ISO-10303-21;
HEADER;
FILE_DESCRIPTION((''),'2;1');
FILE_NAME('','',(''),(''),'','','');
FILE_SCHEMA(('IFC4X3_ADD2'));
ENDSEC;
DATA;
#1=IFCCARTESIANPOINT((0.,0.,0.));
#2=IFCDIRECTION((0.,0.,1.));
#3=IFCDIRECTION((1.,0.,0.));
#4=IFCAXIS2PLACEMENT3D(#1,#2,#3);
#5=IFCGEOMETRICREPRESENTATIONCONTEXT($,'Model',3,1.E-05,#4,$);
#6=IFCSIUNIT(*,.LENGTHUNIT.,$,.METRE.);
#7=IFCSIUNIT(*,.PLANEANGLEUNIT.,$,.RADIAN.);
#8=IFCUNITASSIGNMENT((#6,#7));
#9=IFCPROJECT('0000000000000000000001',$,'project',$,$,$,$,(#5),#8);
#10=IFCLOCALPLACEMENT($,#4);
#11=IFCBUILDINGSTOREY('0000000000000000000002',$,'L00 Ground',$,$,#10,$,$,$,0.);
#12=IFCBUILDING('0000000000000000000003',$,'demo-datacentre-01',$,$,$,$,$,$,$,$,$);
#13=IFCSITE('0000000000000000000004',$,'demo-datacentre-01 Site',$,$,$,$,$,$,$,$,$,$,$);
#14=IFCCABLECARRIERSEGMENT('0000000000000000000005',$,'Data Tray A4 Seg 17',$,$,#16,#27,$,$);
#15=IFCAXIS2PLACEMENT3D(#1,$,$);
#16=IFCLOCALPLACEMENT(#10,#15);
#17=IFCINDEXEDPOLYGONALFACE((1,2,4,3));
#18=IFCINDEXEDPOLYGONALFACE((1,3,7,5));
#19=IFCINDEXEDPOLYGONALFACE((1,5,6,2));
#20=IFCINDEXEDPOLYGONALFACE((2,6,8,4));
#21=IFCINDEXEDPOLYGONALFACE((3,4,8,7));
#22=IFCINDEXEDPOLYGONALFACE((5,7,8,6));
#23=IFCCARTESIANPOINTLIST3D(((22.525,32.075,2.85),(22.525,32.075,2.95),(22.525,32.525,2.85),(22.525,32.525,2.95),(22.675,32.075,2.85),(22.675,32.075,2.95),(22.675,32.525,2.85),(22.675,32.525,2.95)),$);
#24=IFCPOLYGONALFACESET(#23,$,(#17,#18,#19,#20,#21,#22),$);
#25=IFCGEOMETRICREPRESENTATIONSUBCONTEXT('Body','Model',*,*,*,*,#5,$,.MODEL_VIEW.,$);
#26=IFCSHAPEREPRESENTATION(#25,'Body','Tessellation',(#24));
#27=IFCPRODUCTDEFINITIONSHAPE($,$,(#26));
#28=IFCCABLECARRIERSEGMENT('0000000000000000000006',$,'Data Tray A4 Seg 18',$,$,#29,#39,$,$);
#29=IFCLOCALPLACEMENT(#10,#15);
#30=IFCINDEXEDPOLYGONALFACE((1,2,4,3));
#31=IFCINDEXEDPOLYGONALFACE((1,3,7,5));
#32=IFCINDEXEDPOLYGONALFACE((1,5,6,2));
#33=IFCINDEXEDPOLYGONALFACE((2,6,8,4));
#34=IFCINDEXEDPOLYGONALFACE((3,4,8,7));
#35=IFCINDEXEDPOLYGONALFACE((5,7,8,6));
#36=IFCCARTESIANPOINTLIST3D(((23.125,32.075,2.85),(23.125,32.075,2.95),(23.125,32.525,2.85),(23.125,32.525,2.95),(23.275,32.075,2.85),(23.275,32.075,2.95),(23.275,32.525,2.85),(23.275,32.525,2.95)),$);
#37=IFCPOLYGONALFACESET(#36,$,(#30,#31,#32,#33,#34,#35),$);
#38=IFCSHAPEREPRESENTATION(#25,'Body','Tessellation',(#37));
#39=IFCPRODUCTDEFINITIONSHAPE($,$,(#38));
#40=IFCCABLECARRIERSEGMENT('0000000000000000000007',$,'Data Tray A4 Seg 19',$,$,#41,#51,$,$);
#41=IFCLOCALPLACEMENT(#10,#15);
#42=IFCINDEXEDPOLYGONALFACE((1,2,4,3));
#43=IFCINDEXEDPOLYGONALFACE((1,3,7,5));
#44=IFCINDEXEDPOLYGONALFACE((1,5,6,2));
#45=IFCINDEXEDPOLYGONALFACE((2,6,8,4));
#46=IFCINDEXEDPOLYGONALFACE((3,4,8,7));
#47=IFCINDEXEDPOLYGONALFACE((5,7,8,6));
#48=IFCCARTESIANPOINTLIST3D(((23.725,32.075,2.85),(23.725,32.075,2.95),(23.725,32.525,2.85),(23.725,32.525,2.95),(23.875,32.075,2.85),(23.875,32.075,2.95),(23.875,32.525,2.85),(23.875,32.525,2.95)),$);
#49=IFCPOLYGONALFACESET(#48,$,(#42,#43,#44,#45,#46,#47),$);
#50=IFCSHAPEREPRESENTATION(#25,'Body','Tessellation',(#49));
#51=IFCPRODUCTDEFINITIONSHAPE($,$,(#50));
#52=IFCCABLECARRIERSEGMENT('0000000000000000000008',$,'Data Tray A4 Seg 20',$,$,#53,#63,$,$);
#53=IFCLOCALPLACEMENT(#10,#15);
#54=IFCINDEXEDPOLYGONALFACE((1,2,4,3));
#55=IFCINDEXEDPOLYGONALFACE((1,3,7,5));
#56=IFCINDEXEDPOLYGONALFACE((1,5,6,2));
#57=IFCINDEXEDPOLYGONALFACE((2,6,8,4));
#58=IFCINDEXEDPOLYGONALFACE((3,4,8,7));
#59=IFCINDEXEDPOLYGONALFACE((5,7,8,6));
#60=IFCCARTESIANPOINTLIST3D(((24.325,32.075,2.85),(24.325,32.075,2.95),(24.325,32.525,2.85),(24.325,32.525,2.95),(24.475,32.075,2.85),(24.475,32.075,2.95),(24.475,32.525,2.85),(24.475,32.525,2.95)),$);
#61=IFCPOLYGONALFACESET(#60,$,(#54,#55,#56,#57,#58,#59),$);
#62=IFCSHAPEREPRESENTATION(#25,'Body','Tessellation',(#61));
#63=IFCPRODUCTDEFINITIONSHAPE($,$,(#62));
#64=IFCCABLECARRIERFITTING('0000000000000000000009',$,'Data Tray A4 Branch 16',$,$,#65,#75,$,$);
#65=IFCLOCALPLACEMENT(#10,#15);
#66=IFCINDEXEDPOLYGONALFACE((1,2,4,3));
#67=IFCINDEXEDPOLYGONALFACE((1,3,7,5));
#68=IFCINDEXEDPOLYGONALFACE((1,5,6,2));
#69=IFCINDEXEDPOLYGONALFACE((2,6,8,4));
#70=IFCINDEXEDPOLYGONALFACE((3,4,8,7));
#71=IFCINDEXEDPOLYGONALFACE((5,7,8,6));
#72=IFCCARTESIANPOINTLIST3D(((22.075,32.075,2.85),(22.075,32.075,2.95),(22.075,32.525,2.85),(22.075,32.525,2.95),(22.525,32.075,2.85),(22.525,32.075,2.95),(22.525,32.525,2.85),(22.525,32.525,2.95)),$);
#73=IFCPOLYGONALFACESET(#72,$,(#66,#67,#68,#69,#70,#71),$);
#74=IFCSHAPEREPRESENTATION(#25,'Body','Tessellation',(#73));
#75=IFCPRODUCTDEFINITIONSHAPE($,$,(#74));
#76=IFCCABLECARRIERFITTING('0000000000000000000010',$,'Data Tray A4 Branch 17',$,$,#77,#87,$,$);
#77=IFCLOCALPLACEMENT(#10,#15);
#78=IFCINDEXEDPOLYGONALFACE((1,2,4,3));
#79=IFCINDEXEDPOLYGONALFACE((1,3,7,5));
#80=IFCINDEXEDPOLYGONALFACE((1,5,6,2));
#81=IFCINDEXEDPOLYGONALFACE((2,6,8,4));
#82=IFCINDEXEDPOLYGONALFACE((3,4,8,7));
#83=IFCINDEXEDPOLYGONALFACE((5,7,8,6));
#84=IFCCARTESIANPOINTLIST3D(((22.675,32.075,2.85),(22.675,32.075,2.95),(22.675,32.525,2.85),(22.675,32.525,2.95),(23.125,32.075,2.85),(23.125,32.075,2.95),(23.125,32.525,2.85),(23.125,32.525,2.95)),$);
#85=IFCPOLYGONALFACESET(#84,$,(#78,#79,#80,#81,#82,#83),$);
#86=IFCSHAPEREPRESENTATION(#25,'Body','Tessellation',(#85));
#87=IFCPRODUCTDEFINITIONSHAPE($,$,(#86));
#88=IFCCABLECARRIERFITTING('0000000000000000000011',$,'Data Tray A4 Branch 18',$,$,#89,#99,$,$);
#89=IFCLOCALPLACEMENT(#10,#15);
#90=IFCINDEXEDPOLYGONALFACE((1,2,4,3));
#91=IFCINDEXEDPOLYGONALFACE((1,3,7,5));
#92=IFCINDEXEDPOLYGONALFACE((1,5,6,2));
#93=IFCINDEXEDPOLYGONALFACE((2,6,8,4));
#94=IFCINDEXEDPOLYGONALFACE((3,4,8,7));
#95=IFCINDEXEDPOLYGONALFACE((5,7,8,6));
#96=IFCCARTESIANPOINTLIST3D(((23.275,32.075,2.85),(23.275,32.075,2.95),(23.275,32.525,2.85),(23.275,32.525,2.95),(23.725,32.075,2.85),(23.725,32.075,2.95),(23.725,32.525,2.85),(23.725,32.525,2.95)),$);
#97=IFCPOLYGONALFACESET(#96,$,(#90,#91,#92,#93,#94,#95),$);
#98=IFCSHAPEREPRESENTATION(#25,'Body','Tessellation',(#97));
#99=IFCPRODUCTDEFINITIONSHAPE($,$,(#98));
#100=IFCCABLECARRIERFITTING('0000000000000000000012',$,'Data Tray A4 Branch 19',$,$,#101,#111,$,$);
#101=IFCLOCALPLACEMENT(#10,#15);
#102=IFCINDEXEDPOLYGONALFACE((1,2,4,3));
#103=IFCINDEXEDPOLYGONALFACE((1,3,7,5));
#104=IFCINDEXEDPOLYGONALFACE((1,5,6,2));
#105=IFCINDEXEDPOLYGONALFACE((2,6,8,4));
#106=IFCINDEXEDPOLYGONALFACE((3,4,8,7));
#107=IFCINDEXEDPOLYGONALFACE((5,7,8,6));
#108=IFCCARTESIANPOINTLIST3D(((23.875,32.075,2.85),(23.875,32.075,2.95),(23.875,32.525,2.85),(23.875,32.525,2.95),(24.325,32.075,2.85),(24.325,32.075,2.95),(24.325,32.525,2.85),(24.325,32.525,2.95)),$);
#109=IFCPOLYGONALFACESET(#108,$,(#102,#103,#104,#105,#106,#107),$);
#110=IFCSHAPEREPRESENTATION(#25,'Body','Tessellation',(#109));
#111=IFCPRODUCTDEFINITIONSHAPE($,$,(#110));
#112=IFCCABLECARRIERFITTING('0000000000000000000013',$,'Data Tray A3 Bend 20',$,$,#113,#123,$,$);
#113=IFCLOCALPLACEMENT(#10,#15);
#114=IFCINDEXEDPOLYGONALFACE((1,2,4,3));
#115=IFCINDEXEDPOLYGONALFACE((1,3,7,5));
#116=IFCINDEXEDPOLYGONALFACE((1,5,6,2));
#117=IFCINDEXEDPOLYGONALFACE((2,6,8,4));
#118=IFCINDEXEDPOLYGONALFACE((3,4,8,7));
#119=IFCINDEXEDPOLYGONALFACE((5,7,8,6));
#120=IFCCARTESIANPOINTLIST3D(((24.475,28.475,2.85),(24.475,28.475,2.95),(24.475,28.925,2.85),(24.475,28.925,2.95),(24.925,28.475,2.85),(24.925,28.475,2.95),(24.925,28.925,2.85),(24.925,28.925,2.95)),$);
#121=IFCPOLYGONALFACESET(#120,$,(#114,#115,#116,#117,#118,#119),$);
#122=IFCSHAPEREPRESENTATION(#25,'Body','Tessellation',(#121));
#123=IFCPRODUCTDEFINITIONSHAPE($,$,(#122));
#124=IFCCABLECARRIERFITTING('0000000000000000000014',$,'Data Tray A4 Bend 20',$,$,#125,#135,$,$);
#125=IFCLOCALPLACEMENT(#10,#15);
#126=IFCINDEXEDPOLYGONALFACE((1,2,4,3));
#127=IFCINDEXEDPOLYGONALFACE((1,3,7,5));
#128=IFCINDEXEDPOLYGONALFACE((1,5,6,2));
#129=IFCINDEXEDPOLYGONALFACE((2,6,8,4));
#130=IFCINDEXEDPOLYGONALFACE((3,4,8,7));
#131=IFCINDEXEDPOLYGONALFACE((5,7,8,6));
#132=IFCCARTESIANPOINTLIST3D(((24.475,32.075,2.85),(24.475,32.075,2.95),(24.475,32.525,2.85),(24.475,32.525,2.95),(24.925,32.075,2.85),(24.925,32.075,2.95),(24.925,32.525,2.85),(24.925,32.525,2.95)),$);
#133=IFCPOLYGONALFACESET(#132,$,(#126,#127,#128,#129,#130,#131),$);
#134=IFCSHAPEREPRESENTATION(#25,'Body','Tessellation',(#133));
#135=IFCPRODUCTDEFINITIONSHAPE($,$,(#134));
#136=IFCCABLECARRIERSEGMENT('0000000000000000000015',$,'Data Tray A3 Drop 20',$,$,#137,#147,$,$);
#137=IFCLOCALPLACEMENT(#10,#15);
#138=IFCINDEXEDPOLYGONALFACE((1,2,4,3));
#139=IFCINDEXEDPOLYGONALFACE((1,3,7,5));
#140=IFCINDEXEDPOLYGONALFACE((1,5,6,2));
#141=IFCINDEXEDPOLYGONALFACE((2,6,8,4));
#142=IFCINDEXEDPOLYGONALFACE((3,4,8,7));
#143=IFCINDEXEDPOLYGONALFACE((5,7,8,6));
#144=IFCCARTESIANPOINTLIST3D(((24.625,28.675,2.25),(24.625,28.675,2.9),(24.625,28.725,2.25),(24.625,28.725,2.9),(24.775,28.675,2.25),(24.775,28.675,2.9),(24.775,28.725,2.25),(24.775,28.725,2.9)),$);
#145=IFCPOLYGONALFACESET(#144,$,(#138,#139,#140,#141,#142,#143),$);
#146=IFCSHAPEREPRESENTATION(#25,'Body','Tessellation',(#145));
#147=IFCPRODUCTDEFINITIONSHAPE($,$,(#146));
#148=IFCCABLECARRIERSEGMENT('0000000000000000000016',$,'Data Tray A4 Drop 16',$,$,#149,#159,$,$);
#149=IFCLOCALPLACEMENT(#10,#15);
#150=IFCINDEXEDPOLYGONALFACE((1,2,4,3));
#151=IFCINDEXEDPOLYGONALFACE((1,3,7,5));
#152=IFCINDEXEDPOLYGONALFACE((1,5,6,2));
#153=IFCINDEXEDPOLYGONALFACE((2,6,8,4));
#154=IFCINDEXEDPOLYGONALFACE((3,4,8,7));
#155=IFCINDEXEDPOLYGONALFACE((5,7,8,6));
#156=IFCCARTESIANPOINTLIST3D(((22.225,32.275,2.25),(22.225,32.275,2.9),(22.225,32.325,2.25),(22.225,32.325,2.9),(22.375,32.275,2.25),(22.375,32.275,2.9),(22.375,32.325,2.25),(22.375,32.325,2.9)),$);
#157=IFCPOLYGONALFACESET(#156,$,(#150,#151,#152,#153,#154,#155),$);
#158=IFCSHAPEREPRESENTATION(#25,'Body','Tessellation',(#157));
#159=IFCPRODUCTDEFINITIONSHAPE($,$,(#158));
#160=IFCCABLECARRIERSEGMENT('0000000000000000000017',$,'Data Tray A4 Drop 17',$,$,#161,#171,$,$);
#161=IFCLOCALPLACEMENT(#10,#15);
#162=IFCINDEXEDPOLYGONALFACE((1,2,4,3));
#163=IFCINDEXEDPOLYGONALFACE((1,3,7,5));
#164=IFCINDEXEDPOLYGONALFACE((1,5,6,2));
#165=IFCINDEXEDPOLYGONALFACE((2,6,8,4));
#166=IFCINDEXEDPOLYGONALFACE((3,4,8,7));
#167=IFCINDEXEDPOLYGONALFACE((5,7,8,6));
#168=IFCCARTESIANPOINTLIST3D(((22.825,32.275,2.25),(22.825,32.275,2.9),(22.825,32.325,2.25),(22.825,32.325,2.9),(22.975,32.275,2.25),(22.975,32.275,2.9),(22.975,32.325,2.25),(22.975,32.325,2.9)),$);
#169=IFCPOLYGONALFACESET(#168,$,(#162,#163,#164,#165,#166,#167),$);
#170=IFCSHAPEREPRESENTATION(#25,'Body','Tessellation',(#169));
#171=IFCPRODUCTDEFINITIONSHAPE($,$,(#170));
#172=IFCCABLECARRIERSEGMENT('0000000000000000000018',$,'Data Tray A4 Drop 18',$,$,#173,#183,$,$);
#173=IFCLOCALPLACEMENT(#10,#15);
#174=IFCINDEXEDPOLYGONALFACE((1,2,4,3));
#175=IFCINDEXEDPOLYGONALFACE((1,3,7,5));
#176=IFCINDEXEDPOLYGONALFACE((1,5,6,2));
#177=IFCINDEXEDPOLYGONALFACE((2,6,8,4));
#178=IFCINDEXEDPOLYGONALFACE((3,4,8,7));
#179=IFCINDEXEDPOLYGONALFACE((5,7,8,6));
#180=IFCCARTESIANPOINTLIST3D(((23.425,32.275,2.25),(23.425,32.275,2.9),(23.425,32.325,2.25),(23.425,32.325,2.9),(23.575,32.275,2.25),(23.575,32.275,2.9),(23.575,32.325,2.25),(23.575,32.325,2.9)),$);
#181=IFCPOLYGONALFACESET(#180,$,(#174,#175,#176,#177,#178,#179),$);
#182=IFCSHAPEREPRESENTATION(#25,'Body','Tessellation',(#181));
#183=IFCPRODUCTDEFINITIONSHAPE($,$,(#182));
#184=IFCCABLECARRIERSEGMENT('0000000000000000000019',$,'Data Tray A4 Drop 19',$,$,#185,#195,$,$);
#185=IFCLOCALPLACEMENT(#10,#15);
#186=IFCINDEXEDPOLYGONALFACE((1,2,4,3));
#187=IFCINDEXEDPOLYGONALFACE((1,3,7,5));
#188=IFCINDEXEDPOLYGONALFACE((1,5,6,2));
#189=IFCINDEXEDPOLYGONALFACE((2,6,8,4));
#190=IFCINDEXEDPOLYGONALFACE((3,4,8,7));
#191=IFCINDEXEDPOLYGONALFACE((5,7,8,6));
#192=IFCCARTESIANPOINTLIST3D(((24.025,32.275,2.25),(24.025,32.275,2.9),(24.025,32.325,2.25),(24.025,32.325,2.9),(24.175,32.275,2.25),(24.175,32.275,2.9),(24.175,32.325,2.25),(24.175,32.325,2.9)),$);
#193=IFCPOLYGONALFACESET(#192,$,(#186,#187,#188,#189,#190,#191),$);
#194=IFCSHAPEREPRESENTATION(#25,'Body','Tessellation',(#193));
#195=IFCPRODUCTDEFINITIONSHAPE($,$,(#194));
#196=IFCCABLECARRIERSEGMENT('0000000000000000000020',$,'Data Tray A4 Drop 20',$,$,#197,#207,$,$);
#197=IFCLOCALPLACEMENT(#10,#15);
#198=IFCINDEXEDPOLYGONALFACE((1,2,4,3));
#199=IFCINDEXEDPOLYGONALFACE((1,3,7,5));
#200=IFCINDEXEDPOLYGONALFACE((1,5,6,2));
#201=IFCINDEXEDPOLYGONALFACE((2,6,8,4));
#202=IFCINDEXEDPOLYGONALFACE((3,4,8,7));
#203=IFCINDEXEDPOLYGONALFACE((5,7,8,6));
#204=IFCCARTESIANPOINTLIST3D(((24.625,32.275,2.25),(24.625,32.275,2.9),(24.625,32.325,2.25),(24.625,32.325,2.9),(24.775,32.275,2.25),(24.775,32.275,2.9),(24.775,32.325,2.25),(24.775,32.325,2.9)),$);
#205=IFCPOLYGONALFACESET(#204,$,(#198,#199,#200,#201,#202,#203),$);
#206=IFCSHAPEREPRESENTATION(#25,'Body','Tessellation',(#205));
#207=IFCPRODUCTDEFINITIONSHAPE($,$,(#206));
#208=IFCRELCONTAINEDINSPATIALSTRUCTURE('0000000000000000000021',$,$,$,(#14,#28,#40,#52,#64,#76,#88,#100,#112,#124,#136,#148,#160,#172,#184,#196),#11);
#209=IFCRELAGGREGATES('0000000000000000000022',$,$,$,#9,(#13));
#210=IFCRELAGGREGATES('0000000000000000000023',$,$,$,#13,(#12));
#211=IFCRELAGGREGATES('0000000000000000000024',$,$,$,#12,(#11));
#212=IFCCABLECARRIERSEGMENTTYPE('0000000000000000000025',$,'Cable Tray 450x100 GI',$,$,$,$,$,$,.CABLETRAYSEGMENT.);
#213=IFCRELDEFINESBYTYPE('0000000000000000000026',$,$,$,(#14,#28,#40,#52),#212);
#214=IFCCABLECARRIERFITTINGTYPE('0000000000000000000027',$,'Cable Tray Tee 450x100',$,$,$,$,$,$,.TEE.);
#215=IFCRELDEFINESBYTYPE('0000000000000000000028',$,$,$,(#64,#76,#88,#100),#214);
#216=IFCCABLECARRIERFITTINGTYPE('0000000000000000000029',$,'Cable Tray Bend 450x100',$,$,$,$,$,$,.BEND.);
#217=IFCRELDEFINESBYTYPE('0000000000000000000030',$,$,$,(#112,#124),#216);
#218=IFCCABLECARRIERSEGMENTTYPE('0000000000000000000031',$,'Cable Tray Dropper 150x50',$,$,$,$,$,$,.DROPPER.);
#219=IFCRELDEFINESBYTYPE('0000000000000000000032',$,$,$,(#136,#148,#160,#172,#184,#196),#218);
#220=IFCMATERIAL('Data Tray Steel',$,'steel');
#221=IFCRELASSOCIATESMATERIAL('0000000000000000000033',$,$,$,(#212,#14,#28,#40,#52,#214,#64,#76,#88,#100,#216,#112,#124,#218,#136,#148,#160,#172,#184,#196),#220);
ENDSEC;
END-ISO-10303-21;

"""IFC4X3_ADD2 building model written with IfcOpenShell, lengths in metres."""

from ifc_helpers import new_model, si_unit, frame, origin_with_axes, place, context, subcontext, project, spatial, rectangle, extrude, material, type_object, element, save


model = new_model("IFC4X3_ADD2")

# Units and contexts
model_context = context("Model", 3, precision=1e-05, world=origin_with_axes())
body_context = subcontext(model_context, "Body", "Model", "MODEL_VIEW")
ifc_project = project(units=[si_unit("LENGTHUNIT", "METRE"), si_unit("PLANEANGLEUNIT", "RADIAN")], contexts=[model_context])

# Site, building, storey
site = spatial("IfcSite", under=ifc_project, Name="demo-datacentre-01 Site")
building = spatial("IfcBuilding", under=site, Name="demo-datacentre-01")
storey_placement = place(None, origin_with_axes())
storey = spatial("IfcBuildingStorey", under=building, at=storey_placement, Name="L00 Ground", Elevation=0.0)

# Cable carrier segments
ifc_material_1 = material(Name="Data Tray Steel", Category="steel")
cable_carrier_segment_type_1 = type_object("IfcCableCarrierSegmentType", Name="Cable Tray 450x100 GI", PredefinedType="CABLETRAYSEGMENT", material=ifc_material_1)
cable_carrier_segment_placement = place(storey_placement, frame((22.525, 32.3, 2.9), z_axis=(1.0, 0.0, 0.0), x_axis=(0.0, 1.0, 0.0)))
element("IfcCableCarrierSegment", 1, at=cable_carrier_segment_placement, inside=storey, type_object=cable_carrier_segment_type_1, material=ifc_material_1, Name="Data Tray A4 Seg 17", context=body_context, shape_type="SweptSolid", body=[
    extrude(rectangle(XDim=0.45, YDim=0.1), origin_with_axes(), (0.0, 0.0, 1.0), 0.15),
])
for number, where, z_axis, x_axis, name in (
    (2, (23.125, 32.3, 2.9), (1.0, 0.0, 0.0), (0.0, 1.0, 0.0), "Data Tray A4 Seg 18"),
    (3, (23.725, 32.3, 2.9), (1.0, 0.0, 0.0), (0.0, 1.0, 0.0), "Data Tray A4 Seg 19"),
    (4, (24.325, 32.3, 2.9), (1.0, 0.0, 0.0), (0.0, 1.0, 0.0), "Data Tray A4 Seg 20"),
):
    element("IfcCableCarrierSegment", number, at=place(storey_placement, frame(where, z_axis=z_axis, x_axis=x_axis)), inside=storey, type_object=cable_carrier_segment_type_1, material=ifc_material_1, Name=name, context=body_context, shape_type="SweptSolid", body=[
        extrude(rectangle(XDim=0.45, YDim=0.1), origin_with_axes(), (0.0, 0.0, 1.0), 0.15),
    ])

# Cable carrier fittings
cable_carrier_fitting_type_1 = type_object("IfcCableCarrierFittingType", Name="Cable Tray Tee 450x100", PredefinedType="TEE", material=ifc_material_1)
for number, where, z_axis, x_axis, name in (
    (5, (22.3, 32.3, 2.85), (0.0, 0.0, 1.0), (1.0, 0.0, 0.0), "Data Tray A4 Branch 16"),
    (6, (22.9, 32.3, 2.85), (0.0, 0.0, 1.0), (1.0, 0.0, 0.0), "Data Tray A4 Branch 17"),
    (7, (23.5, 32.3, 2.85), (0.0, 0.0, 1.0), (1.0, 0.0, 0.0), "Data Tray A4 Branch 18"),
    (8, (24.1, 32.3, 2.85), (0.0, 0.0, 1.0), (1.0, 0.0, 0.0), "Data Tray A4 Branch 19"),
):
    element("IfcCableCarrierFitting", number, at=place(storey_placement, frame(where, z_axis=z_axis, x_axis=x_axis)), inside=storey, type_object=cable_carrier_fitting_type_1, material=ifc_material_1, Name=name, context=body_context, shape_type="SweptSolid", body=[
        extrude(rectangle(XDim=0.45, YDim=0.45), origin_with_axes(), (0.0, 0.0, 1.0), 0.1),
    ])
cable_carrier_fitting_type_2 = type_object("IfcCableCarrierFittingType", Name="Cable Tray Bend 450x100", PredefinedType="BEND", material=ifc_material_1)
for number, where, z_axis, x_axis, name in (
    (9, (24.7, 28.7, 2.85), (0.0, 0.0, 1.0), (1.0, 0.0, 0.0), "Data Tray A3 Bend 20"),
    (10, (24.7, 32.3, 2.85), (0.0, 0.0, 1.0), (1.0, 0.0, 0.0), "Data Tray A4 Bend 20"),
):
    element("IfcCableCarrierFitting", number, at=place(storey_placement, frame(where, z_axis=z_axis, x_axis=x_axis)), inside=storey, type_object=cable_carrier_fitting_type_2, material=ifc_material_1, Name=name, context=body_context, shape_type="SweptSolid", body=[
        extrude(rectangle(XDim=0.45, YDim=0.45), origin_with_axes(), (0.0, 0.0, 1.0), 0.1),
    ])

# Cable carrier segments
cable_carrier_segment_type_2 = type_object("IfcCableCarrierSegmentType", Name="Cable Tray Dropper 150x50", PredefinedType="DROPPER", material=ifc_material_1)
for number, where, z_axis, x_axis, name in (
    (11, (24.7, 28.7, 2.9), (0.0, 0.0, -1.0), (1.0, 0.0, 0.0), "Data Tray A3 Drop 20"),
    (12, (22.3, 32.3, 2.9), (0.0, 0.0, -1.0), (1.0, 0.0, 0.0), "Data Tray A4 Drop 16"),
    (13, (22.9, 32.3, 2.9), (0.0, 0.0, -1.0), (1.0, 0.0, 0.0), "Data Tray A4 Drop 17"),
    (14, (23.5, 32.3, 2.9), (0.0, 0.0, -1.0), (1.0, 0.0, 0.0), "Data Tray A4 Drop 18"),
    (15, (24.1, 32.3, 2.9), (0.0, 0.0, -1.0), (1.0, 0.0, 0.0), "Data Tray A4 Drop 19"),
    (16, (24.7, 32.3, 2.9), (0.0, 0.0, -1.0), (1.0, 0.0, 0.0), "Data Tray A4 Drop 20"),
):
    element("IfcCableCarrierSegment", number, at=place(storey_placement, frame(where, z_axis=z_axis, x_axis=x_axis)), inside=storey, type_object=cable_carrier_segment_type_2, material=ifc_material_1, Name=name, context=body_context, shape_type="SweptSolid", body=[
        extrude(rectangle(XDim=0.15, YDim=0.05), origin_with_axes(), (0.0, 0.0, 1.0), 0.65),
    ])

save(model, "model.ifc")
